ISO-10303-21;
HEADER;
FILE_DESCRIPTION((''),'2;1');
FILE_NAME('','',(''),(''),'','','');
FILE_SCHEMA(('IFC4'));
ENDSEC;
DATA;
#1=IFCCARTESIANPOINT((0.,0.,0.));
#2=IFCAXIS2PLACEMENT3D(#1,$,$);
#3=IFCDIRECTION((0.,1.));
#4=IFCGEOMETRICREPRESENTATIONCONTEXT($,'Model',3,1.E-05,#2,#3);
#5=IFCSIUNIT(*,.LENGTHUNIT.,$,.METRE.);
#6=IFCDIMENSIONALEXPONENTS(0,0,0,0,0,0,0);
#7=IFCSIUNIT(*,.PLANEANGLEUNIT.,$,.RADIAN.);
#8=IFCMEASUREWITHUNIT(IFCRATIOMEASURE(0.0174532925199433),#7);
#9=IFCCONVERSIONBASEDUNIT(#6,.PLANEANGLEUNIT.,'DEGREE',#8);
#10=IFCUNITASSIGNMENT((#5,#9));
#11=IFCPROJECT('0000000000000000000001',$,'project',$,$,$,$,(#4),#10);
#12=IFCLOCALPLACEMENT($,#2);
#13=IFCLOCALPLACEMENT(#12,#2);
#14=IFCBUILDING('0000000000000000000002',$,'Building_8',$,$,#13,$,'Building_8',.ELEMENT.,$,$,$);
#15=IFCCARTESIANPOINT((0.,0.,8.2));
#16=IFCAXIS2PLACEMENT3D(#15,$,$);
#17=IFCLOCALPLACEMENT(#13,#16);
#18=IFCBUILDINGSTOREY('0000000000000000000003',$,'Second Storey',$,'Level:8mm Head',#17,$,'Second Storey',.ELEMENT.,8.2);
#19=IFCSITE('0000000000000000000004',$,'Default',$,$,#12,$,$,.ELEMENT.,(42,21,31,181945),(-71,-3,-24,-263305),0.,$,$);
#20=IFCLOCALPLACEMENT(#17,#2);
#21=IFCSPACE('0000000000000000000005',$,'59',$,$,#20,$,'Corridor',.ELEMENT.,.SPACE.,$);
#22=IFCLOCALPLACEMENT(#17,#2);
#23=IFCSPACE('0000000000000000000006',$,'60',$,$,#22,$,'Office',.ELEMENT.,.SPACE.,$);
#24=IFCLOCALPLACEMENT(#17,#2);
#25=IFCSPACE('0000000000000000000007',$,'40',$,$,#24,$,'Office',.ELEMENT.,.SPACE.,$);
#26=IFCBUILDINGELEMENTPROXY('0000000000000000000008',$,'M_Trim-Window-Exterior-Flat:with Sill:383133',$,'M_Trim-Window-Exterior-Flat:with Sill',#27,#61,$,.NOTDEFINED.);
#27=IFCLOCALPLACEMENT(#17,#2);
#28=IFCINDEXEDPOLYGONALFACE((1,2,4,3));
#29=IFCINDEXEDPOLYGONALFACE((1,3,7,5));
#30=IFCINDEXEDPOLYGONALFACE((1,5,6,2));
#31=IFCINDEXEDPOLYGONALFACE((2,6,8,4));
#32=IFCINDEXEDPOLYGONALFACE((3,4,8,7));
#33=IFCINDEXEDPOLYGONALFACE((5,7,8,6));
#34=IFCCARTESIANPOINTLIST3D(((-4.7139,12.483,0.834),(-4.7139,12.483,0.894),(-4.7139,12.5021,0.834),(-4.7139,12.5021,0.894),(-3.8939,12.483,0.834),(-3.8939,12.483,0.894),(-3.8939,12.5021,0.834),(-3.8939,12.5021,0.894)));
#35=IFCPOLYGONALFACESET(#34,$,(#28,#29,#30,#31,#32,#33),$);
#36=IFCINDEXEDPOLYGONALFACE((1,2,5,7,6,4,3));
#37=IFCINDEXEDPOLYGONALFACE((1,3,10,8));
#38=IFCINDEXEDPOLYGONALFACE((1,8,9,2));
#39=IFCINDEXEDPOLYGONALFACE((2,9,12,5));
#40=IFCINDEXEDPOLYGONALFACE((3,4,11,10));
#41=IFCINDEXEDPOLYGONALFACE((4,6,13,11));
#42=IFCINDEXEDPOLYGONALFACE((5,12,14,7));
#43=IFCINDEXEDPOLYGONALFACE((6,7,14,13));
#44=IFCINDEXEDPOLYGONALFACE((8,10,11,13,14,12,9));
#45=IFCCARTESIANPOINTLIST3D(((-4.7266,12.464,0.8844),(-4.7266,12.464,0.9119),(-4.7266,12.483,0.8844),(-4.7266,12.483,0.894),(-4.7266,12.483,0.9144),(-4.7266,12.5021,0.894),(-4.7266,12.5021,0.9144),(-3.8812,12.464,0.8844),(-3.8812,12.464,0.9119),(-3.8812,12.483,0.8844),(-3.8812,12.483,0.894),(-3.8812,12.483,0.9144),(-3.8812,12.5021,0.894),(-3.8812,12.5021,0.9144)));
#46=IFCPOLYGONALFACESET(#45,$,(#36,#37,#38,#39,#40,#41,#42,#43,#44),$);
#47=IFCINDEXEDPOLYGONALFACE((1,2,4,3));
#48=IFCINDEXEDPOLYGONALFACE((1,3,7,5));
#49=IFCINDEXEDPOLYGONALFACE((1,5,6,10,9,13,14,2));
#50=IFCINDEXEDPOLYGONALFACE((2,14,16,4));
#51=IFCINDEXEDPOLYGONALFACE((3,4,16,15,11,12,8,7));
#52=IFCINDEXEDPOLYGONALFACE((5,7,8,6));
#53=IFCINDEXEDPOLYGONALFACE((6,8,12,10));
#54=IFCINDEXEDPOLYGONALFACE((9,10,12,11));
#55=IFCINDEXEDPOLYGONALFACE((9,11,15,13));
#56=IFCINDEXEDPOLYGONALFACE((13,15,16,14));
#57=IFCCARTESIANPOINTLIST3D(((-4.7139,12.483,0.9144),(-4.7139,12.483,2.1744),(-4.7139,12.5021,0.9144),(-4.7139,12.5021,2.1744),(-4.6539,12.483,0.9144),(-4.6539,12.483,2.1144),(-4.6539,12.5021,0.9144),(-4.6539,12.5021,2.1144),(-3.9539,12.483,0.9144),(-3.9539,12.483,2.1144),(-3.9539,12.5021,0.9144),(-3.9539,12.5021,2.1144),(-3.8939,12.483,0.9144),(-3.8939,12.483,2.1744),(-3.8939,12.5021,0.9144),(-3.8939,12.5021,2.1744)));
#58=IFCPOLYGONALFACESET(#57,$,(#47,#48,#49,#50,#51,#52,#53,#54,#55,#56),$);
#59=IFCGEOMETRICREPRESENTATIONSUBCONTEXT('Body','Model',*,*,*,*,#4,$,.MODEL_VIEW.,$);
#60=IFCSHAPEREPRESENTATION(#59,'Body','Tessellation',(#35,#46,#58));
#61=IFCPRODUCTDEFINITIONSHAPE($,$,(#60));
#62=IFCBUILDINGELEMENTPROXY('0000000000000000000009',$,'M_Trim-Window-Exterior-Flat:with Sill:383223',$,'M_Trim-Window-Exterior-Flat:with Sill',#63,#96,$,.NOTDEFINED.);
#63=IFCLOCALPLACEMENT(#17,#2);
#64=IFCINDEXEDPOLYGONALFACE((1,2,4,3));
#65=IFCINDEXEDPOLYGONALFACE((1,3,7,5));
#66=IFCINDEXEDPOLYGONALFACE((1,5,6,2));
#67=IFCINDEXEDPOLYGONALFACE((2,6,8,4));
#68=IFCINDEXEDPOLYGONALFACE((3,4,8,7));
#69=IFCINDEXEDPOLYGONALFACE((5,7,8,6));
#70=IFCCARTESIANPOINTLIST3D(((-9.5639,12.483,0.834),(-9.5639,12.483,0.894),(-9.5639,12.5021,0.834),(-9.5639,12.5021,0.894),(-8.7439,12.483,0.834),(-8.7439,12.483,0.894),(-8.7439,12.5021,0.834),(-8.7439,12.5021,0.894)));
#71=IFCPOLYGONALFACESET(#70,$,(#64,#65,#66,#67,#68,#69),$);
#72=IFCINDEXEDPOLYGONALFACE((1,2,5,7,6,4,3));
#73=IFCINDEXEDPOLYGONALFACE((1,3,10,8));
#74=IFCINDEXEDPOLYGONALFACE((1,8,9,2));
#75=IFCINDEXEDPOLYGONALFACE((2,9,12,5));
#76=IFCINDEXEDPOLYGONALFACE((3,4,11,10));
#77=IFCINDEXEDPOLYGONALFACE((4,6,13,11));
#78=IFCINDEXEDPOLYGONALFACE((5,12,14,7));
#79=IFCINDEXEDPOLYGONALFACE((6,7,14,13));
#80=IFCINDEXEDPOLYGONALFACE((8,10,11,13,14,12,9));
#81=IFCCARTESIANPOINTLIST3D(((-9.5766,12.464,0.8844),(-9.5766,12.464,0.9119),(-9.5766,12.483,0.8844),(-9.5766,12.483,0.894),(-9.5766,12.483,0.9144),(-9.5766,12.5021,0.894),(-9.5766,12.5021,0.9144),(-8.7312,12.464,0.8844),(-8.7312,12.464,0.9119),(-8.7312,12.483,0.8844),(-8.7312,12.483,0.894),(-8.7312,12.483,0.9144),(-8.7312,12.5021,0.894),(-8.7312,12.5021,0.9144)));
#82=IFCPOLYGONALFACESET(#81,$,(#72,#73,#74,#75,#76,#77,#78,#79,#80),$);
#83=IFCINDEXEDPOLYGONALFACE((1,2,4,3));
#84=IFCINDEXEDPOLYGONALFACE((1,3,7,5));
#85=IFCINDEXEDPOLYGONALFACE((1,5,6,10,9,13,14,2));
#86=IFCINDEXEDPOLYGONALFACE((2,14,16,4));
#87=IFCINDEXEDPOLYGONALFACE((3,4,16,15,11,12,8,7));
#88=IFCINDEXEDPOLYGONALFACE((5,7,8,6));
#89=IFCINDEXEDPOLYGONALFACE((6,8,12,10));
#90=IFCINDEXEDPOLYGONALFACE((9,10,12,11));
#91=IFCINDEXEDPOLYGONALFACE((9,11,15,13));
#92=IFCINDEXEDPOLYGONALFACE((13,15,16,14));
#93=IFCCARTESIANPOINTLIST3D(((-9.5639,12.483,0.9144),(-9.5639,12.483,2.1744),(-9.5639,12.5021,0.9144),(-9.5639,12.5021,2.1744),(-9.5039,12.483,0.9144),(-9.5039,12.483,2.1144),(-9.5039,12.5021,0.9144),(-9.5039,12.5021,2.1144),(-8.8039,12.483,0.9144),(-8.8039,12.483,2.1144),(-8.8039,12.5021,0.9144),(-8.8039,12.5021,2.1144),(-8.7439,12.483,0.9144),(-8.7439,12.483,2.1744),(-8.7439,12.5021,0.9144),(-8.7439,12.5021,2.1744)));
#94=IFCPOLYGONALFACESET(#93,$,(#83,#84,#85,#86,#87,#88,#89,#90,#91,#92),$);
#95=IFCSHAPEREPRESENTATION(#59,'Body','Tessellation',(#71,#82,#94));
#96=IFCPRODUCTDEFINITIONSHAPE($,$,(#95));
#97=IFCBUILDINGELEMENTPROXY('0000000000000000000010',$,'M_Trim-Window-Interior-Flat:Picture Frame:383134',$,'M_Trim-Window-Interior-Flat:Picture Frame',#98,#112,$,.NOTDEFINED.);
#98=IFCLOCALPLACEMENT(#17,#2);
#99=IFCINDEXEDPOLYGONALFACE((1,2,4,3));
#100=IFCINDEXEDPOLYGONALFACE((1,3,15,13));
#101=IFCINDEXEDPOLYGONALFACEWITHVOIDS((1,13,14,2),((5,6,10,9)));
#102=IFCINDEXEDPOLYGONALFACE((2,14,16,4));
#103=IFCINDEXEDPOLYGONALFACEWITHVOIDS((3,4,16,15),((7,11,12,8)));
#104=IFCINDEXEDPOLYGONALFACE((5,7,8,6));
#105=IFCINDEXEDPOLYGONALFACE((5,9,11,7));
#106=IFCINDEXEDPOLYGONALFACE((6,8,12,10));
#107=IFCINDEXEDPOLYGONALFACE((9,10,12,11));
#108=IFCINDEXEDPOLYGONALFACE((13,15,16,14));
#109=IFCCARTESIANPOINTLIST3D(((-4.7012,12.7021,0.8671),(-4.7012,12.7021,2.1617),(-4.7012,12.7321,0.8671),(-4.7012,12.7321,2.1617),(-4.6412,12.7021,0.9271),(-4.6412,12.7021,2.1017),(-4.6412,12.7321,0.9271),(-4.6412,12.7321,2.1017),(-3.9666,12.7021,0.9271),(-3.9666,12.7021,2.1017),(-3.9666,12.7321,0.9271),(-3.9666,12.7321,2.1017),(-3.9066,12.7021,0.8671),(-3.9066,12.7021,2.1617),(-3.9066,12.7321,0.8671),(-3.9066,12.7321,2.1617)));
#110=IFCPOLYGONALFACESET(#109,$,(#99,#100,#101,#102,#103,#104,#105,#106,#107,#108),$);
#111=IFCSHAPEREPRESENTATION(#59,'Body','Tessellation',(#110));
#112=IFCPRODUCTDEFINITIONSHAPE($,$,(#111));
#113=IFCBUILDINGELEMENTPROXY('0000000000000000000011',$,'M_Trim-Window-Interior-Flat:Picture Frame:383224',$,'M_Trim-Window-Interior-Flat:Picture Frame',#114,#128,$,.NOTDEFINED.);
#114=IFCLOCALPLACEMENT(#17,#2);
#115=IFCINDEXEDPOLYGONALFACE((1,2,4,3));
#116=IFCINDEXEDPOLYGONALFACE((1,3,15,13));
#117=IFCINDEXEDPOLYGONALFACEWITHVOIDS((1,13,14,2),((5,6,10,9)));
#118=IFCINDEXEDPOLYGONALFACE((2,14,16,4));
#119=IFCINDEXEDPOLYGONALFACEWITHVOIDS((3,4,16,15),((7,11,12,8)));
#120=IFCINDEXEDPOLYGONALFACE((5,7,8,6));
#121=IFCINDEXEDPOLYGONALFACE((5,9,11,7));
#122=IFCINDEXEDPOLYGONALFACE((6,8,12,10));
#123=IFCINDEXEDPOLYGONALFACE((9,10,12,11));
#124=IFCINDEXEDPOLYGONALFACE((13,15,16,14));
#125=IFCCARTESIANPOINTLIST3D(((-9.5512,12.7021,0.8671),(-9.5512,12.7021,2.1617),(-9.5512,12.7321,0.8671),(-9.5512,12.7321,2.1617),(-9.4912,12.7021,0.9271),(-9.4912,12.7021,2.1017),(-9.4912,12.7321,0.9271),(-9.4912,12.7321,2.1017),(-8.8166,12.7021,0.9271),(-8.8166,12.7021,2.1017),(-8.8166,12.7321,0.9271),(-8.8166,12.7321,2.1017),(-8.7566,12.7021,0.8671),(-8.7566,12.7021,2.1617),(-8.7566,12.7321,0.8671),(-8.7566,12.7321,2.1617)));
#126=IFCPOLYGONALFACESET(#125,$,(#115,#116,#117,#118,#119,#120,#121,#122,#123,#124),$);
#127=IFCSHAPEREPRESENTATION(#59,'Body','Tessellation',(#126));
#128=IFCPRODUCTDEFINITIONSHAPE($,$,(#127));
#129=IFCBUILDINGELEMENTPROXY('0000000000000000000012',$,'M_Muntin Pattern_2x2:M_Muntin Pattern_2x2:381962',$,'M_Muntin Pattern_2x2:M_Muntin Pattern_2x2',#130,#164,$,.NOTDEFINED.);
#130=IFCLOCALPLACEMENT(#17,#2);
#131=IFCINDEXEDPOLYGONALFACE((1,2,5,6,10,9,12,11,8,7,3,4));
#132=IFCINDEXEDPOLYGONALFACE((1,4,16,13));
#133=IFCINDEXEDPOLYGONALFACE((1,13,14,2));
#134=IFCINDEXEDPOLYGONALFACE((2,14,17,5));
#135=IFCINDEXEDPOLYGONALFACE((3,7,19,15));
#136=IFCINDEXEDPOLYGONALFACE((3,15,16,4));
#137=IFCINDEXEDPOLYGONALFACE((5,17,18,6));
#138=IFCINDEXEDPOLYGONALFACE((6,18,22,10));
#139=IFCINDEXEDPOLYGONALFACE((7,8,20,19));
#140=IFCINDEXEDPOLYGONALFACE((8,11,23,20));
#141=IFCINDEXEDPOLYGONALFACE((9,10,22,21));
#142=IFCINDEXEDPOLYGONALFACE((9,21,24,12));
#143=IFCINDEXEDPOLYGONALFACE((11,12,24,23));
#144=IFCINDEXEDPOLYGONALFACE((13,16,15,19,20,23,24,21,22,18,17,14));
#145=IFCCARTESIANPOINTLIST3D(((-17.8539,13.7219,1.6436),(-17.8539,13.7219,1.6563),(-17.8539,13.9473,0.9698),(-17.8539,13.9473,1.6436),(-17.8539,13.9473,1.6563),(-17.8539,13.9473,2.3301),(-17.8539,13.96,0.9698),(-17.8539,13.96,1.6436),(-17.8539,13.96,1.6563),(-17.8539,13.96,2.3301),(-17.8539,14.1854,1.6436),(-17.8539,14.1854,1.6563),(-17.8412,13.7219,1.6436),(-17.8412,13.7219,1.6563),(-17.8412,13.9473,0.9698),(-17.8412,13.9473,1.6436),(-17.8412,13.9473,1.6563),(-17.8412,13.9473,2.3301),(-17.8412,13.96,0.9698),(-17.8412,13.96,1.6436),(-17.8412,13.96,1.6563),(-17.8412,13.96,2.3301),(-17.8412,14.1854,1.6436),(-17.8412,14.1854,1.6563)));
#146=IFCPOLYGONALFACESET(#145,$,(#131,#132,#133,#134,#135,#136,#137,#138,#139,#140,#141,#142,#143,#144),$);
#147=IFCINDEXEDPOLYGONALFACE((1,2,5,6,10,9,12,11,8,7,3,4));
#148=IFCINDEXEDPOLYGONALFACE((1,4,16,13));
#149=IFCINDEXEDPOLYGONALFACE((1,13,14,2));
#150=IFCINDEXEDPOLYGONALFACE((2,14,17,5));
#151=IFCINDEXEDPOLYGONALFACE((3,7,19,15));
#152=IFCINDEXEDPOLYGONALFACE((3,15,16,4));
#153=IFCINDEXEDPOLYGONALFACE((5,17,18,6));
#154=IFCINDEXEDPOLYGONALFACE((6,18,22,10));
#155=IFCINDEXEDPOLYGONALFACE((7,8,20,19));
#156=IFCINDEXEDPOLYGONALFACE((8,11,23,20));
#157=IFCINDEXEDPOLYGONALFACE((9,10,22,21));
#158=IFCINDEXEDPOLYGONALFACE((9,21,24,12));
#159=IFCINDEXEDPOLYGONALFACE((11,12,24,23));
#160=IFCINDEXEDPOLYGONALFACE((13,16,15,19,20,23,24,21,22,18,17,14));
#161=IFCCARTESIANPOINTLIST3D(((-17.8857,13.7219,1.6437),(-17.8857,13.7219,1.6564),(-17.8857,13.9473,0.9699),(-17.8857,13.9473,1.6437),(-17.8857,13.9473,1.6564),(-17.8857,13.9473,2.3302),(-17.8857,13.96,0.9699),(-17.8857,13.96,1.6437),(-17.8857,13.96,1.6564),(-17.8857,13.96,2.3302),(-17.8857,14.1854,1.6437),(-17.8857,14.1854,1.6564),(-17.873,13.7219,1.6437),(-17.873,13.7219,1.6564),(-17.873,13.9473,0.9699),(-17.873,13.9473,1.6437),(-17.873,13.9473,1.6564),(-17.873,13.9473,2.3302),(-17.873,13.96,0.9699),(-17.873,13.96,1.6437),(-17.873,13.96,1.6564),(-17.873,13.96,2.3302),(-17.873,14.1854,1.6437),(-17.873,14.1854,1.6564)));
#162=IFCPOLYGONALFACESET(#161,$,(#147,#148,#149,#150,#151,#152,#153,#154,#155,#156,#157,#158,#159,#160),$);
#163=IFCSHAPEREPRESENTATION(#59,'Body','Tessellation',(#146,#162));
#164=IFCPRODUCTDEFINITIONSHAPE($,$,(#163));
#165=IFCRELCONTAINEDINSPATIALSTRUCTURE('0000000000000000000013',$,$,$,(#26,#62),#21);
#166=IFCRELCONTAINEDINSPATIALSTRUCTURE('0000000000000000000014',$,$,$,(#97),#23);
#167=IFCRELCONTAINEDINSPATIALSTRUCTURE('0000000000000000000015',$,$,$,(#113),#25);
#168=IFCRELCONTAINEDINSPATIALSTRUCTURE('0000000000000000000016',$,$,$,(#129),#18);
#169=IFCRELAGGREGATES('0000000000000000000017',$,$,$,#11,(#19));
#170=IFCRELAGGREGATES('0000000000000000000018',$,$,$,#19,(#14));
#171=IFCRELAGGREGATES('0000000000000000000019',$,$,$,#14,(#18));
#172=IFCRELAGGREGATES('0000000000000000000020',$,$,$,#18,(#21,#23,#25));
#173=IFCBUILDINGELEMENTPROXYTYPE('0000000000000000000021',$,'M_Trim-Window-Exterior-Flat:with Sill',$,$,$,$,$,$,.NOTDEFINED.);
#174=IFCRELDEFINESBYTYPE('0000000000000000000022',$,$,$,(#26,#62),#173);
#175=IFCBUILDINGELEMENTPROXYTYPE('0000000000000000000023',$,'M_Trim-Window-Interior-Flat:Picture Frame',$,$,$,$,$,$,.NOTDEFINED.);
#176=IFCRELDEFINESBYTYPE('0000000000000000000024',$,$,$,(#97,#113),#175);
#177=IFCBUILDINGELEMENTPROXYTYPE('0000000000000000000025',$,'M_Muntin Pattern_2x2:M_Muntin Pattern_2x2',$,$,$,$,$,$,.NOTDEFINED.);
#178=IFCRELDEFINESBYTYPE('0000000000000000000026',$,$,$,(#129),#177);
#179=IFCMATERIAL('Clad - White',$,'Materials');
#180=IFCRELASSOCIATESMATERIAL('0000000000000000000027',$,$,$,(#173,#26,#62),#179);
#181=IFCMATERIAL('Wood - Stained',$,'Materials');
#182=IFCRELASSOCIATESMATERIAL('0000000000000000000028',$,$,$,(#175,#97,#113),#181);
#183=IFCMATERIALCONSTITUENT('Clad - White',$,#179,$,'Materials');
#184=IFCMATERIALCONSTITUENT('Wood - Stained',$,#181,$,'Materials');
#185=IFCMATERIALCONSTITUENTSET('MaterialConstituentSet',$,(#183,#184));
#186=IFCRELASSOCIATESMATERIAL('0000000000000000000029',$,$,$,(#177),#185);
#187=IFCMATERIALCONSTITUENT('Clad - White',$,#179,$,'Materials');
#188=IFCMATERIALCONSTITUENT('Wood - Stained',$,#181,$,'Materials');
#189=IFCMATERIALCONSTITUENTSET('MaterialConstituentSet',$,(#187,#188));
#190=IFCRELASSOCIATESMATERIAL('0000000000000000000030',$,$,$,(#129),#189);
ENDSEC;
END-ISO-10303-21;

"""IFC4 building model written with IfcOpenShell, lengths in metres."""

from ifc_helpers import new_model, entity, si_unit, converted_unit, direction, frame, origin, place, context, subcontext, project, spatial, indexed_curve, outline, extrude, source, transform, mapped, material, constituent, constituent_set, type_object, type_shapes, element, save


model = new_model("IFC4")

# Units and contexts
model_context = context("Model", 3, precision=1e-05, world=origin(), true_north=direction((0.0, 1.0)))
body_context = subcontext(model_context, "Body", "Model", "MODEL_VIEW")
ifc_project = project(units=[si_unit("LENGTHUNIT", "METRE"), converted_unit("PLANEANGLEUNIT", "DEGREE", entity("IfcRatioMeasure", 0.0174532925199433), si_unit("PLANEANGLEUNIT", "RADIAN"), dimensions=[0, 0, 0, 0, 0, 0, 0])], contexts=[model_context])

# Site, building, storey
site_placement = place(None, origin())
site = spatial("IfcSite", under=ifc_project, at=site_placement, Name="Default", CompositionType="ELEMENT", RefLatitude=(42, 21, 31, 181945), RefLongitude=(-71, -3, -24, -263305), RefElevation=0.0)
building_placement = place(site_placement, origin())
building = spatial("IfcBuilding", under=site, at=building_placement, Name="Building_8", LongName="Building_8", CompositionType="ELEMENT")
storey_placement = place(building_placement, frame((0.0, 0.0, 8.2)))
storey = spatial("IfcBuildingStorey", under=building, at=storey_placement, Name="Second Storey", ObjectType="Level:8mm Head", LongName="Second Storey", CompositionType="ELEMENT", Elevation=8.2)

# Shared definitions
ifc_material_1 = material(Name="Clad - White", Category="Materials")
ifc_material_2 = material(Name="Wood - Stained", Category="Materials")

# Shared definitions
space_1_placement = place(storey_placement, origin())
space_1 = spatial("IfcSpace", under=storey, at=space_1_placement, Name="59", LongName="Corridor", CompositionType="ELEMENT", PredefinedType="SPACE")

# Building element proxies
building_element_proxy_type_1 = type_object("IfcBuildingElementProxyType", Name="M_Trim-Window-Exterior-Flat:with Sill", PredefinedType="NOTDEFINED", material=ifc_material_1)
shared_shape_1 = source(origin(), body_context, "Body", "SweptSolid", [
    extrude(outline(indexed_curve([(-0.41, -0.03), (0.41, -0.03), (0.41, 0.03), (-0.41, 0.03), (-0.41, -0.03)], self_intersect=False)), frame((0.0, -1.2504, 0.0), z_axis=(0.0, 0.0, 1.0), x_axis=(-1.0, 0.0, 0.0)), (0.0, 0.0, 1.0), 0.0191),
    extrude(outline(indexed_curve([(-0.019, -0.0152), (0.0, -0.0152), (0.0, -0.0057), (0.019, -0.0057), (0.019, 0.0148), (0.0, 0.0148), (-0.019, 0.0123), (-0.019, -0.0152)], self_intersect=False)), frame((-0.4227, -1.2148, 0.019), z_axis=(1.0, 0.0, 0.0), x_axis=(0.0, 0.0, -1.0)), (0.0, 0.0, 1.0), 0.8454),
    extrude(outline(indexed_curve([(-0.645, -0.41), (0.615, -0.41), (0.615, -0.35), (-0.585, -0.35), (-0.585, 0.35), (0.615, 0.35), (0.615, 0.41), (-0.645, 0.41), (-0.645, -0.41)], self_intersect=False)), frame((0.0, -0.585, 0.0), z_axis=(0.0, 0.0, 1.0), x_axis=(0.0, -1.0, 0.0)), (0.0, 0.0, 1.0), 0.0191),
])
type_shapes(building_element_proxy_type_1, [shared_shape_1])
for number, where, z_axis, x_axis, name in (
    (1, (-4.3039, 12.5021, 2.1144), (0.0, -1.0, 0.0), (1.0, 0.0, 0.0), "M_Trim-Window-Exterior-Flat:with Sill:383133"),
    (2, (-9.1539, 12.5021, 2.1144), (0.0, -1.0, 0.0), (1.0, 0.0, 0.0), "M_Trim-Window-Exterior-Flat:with Sill:383223"),
):
    element("IfcBuildingElementProxy", number, at=place(space_1_placement, frame(where, z_axis=z_axis, x_axis=x_axis)), inside=space_1, type_object=building_element_proxy_type_1, material=ifc_material_1, Name=name, ObjectType="M_Trim-Window-Exterior-Flat:with Sill", PredefinedType="NOTDEFINED", context=body_context, shape_type="MappedRepresentation", body=[
        mapped(shared_shape_1, transform((0.0, 0.0, 0.0), scale=1.0)),
    ])

# Shared definitions
space_2_placement = place(storey_placement, origin())
space_2 = spatial("IfcSpace", under=storey, at=space_2_placement, Name="60", LongName="Office", CompositionType="ELEMENT", PredefinedType="SPACE")

# Building element proxy
building_element_proxy_type_2 = type_object("IfcBuildingElementProxyType", Name="M_Trim-Window-Interior-Flat:Picture Frame", PredefinedType="NOTDEFINED", material=ifc_material_2)
shared_shape_2 = source(origin(), body_context, "Body", "SweptSolid", [
    extrude(outline(indexed_curve([(-0.3973, -0.6473), (0.3973, -0.6473), (0.3973, 0.6473), (-0.3973, 0.6473), (-0.3973, -0.6473)], self_intersect=False), holes=[indexed_curve([(-0.3373, -0.5873), (-0.3373, 0.5873), (0.3373, 0.5873), (0.3373, -0.5873), (-0.3373, -0.5873)], self_intersect=False)]), frame((0.0, -0.6, 0.0), z_axis=(0.0, 0.0, 1.0), x_axis=(-1.0, 0.0, 0.0)), (0.0, 0.0, 1.0), 0.03),
])
type_shapes(building_element_proxy_type_2, [shared_shape_2])
proxy_1_placement = place(space_2_placement, frame((-4.3039, 12.7021, 2.1144), z_axis=(0.0, 1.0, 0.0), x_axis=(-1.0, 0.0, 0.0)))
element("IfcBuildingElementProxy", 3, at=proxy_1_placement, inside=space_2, type_object=building_element_proxy_type_2, material=ifc_material_2, Name="M_Trim-Window-Interior-Flat:Picture Frame:383134", ObjectType="M_Trim-Window-Interior-Flat:Picture Frame", PredefinedType="NOTDEFINED", context=body_context, shape_type="MappedRepresentation", body=[
    mapped(shared_shape_2, transform((0.0, 0.0, 0.0), scale=1.0)),
])

# Shared definitions
space_3_placement = place(storey_placement, origin())
space_3 = spatial("IfcSpace", under=storey, at=space_3_placement, Name="40", LongName="Office", CompositionType="ELEMENT", PredefinedType="SPACE")

# Building element proxies
proxy_2_placement = place(space_3_placement, frame((-9.1539, 12.7021, 2.1144), z_axis=(0.0, 1.0, 0.0), x_axis=(-1.0, 0.0, 0.0)))
element("IfcBuildingElementProxy", 4, at=proxy_2_placement, inside=space_3, type_object=building_element_proxy_type_2, material=ifc_material_2, Name="M_Trim-Window-Interior-Flat:Picture Frame:383224", ObjectType="M_Trim-Window-Interior-Flat:Picture Frame", PredefinedType="NOTDEFINED", context=body_context, shape_type="MappedRepresentation", body=[
    mapped(shared_shape_2, transform((0.0, 0.0, 0.0), scale=1.0)),
])
ifc_constituent_1 = constituent(ifc_material_1, Name="Clad - White", Category="Materials")
ifc_constituent_2 = constituent(ifc_material_2, Name="Wood - Stained", Category="Materials")
ifc_constituent_set_1 = constituent_set(constituents=[ifc_constituent_1, ifc_constituent_2], Name="MaterialConstituentSet")
ifc_constituent_3 = constituent(ifc_material_1, Name="Clad - White", Category="Materials")
ifc_constituent_4 = constituent(ifc_material_2, Name="Wood - Stained", Category="Materials")
ifc_constituent_set_2 = constituent_set(constituents=[ifc_constituent_3, ifc_constituent_4], Name="MaterialConstituentSet")
building_element_proxy_type_3 = type_object("IfcBuildingElementProxyType", Name="M_Muntin Pattern_2x2:M_Muntin Pattern_2x2", PredefinedType="NOTDEFINED", material=ifc_constituent_set_2)
shared_shape_3 = source(origin(), body_context, "Body", "SweptSolid", [
    extrude(outline(indexed_curve([(0.0064, -0.0064), (0.6801, -0.0064), (0.6801, 0.0063), (0.0064, 0.0063), (0.0064, 0.2317), (-0.0063, 0.2317), (-0.0063, 0.0063), (-0.6802, 0.0063), (-0.6802, -0.0064), (-0.0063, -0.0064), (-0.0063, -0.2317), (0.0064, -0.2317), (0.0064, -0.0064)], self_intersect=False)), frame((0.0, -0.0222, 0.6801), z_axis=(0.0, 1.0, 0.0), x_axis=(0.0, 0.0, 1.0)), (0.0, 0.0, 1.0), 0.0127),
    extrude(outline(indexed_curve([(0.0064, -0.0064), (0.6802, -0.0064), (0.6802, 0.0063), (0.0064, 0.0063), (0.0064, 0.2317), (-0.0063, 0.2317), (-0.0063, 0.0063), (-0.6802, 0.0063), (-0.6802, -0.0064), (-0.0063, -0.0064), (-0.0063, -0.2317), (0.0064, -0.2317), (0.0064, -0.0064)], self_intersect=False)), frame((0.0, 0.0095, 0.6802), z_axis=(0.0, 1.0, 0.0), x_axis=(0.0, 0.0, 1.0)), (0.0, 0.0, 1.0), 0.0127),
])
type_shapes(building_element_proxy_type_3, [shared_shape_3])
proxy_3_placement = place(storey_placement, frame((-17.8634, 13.9537, 0.9699), z_axis=(0.0, 0.0, 1.0), x_axis=(0.0, 1.0, 0.0)))
element("IfcBuildingElementProxy", 5, at=proxy_3_placement, inside=storey, type_object=building_element_proxy_type_3, material=ifc_constituent_set_1, Name="M_Muntin Pattern_2x2:M_Muntin Pattern_2x2:381962", ObjectType="M_Muntin Pattern_2x2:M_Muntin Pattern_2x2", PredefinedType="NOTDEFINED", context=body_context, shape_type="MappedRepresentation", body=[
    mapped(shared_shape_3, transform((0.0, 0.0, 0.0), scale=1.0)),
])

save(model, "model.ifc")
